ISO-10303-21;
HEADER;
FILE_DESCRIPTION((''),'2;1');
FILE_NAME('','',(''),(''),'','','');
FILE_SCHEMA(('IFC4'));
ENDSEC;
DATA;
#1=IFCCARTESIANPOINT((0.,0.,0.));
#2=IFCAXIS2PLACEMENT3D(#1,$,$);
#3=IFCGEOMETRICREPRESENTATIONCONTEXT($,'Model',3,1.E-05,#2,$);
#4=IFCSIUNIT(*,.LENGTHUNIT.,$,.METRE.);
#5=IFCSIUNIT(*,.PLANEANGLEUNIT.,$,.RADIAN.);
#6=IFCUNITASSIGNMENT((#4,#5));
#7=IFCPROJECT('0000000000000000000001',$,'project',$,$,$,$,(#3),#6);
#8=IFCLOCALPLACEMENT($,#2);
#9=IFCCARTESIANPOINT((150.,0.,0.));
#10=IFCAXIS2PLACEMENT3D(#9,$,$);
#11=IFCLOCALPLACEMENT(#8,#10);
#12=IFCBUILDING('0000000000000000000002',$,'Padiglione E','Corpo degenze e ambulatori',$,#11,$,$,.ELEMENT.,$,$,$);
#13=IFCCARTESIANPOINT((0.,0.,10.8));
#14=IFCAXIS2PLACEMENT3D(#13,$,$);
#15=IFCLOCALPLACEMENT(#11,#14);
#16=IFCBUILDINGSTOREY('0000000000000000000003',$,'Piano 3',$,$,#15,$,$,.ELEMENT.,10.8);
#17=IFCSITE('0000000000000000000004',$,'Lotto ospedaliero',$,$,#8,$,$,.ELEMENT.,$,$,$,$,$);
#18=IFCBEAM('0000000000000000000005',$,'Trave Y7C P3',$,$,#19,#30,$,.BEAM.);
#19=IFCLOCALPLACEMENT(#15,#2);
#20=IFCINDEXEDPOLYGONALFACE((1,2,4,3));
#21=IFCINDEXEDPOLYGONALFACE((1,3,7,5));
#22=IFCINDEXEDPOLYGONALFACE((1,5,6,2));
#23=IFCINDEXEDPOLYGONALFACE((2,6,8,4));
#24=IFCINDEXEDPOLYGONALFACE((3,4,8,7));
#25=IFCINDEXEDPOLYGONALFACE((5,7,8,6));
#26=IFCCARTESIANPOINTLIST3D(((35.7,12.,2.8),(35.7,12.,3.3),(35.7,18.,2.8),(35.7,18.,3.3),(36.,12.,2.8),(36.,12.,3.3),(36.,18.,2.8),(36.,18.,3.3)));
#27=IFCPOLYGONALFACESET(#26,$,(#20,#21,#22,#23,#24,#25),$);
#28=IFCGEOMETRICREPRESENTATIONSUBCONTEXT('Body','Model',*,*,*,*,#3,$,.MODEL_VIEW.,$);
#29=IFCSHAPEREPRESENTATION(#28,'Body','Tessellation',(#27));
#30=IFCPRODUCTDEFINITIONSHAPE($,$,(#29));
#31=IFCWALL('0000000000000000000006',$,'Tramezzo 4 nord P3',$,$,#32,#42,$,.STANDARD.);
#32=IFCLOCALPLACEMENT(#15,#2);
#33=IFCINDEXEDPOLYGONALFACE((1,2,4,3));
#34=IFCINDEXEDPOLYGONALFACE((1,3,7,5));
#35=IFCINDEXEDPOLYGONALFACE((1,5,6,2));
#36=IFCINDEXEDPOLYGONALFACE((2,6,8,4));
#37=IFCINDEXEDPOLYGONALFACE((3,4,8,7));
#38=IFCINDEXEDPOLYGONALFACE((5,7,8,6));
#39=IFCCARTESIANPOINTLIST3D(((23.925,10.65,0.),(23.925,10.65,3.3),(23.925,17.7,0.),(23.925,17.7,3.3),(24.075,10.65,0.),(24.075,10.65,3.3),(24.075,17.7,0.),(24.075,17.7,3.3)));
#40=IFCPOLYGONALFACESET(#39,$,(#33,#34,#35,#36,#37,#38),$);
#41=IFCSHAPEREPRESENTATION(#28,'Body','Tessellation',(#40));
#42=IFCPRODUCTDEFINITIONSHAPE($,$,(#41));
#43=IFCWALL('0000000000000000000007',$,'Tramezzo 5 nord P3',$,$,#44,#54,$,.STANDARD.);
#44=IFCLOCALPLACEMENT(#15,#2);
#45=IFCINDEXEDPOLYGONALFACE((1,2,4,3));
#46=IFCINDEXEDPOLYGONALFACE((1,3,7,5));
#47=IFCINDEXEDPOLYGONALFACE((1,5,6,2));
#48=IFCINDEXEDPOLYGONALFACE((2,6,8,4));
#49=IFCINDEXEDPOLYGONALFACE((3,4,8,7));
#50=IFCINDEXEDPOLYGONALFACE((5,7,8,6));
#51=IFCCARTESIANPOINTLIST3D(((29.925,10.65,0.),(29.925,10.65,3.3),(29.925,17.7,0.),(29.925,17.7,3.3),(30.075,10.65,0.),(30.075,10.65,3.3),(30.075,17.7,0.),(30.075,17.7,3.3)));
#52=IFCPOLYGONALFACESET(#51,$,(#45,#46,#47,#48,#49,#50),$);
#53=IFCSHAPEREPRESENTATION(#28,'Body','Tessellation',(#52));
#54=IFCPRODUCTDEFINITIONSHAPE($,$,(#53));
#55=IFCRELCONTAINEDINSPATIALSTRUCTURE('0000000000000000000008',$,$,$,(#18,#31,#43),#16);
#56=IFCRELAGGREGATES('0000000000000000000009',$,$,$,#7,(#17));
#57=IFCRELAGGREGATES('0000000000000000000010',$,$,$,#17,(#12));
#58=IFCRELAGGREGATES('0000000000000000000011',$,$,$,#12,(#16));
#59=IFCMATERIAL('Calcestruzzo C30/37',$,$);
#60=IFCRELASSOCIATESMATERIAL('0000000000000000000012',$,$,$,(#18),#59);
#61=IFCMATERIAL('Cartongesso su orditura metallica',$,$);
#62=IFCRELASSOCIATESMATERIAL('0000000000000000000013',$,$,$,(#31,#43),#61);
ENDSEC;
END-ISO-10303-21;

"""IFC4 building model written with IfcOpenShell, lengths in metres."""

from ifc_helpers import new_model, si_unit, frame, frame_2d, origin, place, context, subcontext, project, spatial, rectangle, extrude, material, element, save


model = new_model("IFC4")

# Units and contexts
model_context = context("Model", 3, precision=1e-05, world=origin())
body_context = subcontext(model_context, "Body", "Model", "MODEL_VIEW")
ifc_project = project(units=[si_unit("LENGTHUNIT", "METRE"), si_unit("PLANEANGLEUNIT", "RADIAN")], contexts=[model_context])

# Site, building, storey
site_placement = place(None, origin())
site = spatial("IfcSite", under=ifc_project, at=site_placement, Name="Lotto ospedaliero", CompositionType="ELEMENT")
building_placement = place(site_placement, frame((150.0, 0.0, 0.0)))
building = spatial("IfcBuilding", under=site, at=building_placement, Name="Padiglione E", Description="Corpo degenze e ambulatori", CompositionType="ELEMENT")
storey_placement = place(building_placement, frame((0.0, 0.0, 10.8)))
storey = spatial("IfcBuildingStorey", under=building, at=storey_placement, Name="Piano 3", CompositionType="ELEMENT", Elevation=10.8)

# Shared definitions
ifc_material_1 = material(Name="Calcestruzzo C30/37")

# Beam
for number, where, name in (
    (1, (35.7, 12.0, 2.8), "Trave Y7C P3"),
):
    element("IfcBeam", number, at=place(storey_placement, frame(where)), inside=storey, material=ifc_material_1, Name=name, PredefinedType="BEAM", context=body_context, shape_type="SweptSolid", body=[
        extrude(rectangle(XDim=0.3, YDim=6.0, at=frame_2d((0.15, 3.0))), origin(), (0.0, 0.0, 1.0), 0.5),
    ])

# Walls
ifc_material_2 = material(Name="Cartongesso su orditura metallica")
for number, where, name in (
    (2, (23.925, 10.65, 0.0), "Tramezzo 4 nord P3"),
    (3, (29.925, 10.65, 0.0), "Tramezzo 5 nord P3"),
):
    element("IfcWall", number, at=place(storey_placement, frame(where)), inside=storey, material=ifc_material_2, Name=name, PredefinedType="STANDARD", context=body_context, shape_type="SweptSolid", body=[
        extrude(rectangle(XDim=0.15, YDim=7.05, at=frame_2d((0.075, 3.525))), origin(), (0.0, 0.0, 1.0), 3.3),
    ])

save(model, "model.ifc")
